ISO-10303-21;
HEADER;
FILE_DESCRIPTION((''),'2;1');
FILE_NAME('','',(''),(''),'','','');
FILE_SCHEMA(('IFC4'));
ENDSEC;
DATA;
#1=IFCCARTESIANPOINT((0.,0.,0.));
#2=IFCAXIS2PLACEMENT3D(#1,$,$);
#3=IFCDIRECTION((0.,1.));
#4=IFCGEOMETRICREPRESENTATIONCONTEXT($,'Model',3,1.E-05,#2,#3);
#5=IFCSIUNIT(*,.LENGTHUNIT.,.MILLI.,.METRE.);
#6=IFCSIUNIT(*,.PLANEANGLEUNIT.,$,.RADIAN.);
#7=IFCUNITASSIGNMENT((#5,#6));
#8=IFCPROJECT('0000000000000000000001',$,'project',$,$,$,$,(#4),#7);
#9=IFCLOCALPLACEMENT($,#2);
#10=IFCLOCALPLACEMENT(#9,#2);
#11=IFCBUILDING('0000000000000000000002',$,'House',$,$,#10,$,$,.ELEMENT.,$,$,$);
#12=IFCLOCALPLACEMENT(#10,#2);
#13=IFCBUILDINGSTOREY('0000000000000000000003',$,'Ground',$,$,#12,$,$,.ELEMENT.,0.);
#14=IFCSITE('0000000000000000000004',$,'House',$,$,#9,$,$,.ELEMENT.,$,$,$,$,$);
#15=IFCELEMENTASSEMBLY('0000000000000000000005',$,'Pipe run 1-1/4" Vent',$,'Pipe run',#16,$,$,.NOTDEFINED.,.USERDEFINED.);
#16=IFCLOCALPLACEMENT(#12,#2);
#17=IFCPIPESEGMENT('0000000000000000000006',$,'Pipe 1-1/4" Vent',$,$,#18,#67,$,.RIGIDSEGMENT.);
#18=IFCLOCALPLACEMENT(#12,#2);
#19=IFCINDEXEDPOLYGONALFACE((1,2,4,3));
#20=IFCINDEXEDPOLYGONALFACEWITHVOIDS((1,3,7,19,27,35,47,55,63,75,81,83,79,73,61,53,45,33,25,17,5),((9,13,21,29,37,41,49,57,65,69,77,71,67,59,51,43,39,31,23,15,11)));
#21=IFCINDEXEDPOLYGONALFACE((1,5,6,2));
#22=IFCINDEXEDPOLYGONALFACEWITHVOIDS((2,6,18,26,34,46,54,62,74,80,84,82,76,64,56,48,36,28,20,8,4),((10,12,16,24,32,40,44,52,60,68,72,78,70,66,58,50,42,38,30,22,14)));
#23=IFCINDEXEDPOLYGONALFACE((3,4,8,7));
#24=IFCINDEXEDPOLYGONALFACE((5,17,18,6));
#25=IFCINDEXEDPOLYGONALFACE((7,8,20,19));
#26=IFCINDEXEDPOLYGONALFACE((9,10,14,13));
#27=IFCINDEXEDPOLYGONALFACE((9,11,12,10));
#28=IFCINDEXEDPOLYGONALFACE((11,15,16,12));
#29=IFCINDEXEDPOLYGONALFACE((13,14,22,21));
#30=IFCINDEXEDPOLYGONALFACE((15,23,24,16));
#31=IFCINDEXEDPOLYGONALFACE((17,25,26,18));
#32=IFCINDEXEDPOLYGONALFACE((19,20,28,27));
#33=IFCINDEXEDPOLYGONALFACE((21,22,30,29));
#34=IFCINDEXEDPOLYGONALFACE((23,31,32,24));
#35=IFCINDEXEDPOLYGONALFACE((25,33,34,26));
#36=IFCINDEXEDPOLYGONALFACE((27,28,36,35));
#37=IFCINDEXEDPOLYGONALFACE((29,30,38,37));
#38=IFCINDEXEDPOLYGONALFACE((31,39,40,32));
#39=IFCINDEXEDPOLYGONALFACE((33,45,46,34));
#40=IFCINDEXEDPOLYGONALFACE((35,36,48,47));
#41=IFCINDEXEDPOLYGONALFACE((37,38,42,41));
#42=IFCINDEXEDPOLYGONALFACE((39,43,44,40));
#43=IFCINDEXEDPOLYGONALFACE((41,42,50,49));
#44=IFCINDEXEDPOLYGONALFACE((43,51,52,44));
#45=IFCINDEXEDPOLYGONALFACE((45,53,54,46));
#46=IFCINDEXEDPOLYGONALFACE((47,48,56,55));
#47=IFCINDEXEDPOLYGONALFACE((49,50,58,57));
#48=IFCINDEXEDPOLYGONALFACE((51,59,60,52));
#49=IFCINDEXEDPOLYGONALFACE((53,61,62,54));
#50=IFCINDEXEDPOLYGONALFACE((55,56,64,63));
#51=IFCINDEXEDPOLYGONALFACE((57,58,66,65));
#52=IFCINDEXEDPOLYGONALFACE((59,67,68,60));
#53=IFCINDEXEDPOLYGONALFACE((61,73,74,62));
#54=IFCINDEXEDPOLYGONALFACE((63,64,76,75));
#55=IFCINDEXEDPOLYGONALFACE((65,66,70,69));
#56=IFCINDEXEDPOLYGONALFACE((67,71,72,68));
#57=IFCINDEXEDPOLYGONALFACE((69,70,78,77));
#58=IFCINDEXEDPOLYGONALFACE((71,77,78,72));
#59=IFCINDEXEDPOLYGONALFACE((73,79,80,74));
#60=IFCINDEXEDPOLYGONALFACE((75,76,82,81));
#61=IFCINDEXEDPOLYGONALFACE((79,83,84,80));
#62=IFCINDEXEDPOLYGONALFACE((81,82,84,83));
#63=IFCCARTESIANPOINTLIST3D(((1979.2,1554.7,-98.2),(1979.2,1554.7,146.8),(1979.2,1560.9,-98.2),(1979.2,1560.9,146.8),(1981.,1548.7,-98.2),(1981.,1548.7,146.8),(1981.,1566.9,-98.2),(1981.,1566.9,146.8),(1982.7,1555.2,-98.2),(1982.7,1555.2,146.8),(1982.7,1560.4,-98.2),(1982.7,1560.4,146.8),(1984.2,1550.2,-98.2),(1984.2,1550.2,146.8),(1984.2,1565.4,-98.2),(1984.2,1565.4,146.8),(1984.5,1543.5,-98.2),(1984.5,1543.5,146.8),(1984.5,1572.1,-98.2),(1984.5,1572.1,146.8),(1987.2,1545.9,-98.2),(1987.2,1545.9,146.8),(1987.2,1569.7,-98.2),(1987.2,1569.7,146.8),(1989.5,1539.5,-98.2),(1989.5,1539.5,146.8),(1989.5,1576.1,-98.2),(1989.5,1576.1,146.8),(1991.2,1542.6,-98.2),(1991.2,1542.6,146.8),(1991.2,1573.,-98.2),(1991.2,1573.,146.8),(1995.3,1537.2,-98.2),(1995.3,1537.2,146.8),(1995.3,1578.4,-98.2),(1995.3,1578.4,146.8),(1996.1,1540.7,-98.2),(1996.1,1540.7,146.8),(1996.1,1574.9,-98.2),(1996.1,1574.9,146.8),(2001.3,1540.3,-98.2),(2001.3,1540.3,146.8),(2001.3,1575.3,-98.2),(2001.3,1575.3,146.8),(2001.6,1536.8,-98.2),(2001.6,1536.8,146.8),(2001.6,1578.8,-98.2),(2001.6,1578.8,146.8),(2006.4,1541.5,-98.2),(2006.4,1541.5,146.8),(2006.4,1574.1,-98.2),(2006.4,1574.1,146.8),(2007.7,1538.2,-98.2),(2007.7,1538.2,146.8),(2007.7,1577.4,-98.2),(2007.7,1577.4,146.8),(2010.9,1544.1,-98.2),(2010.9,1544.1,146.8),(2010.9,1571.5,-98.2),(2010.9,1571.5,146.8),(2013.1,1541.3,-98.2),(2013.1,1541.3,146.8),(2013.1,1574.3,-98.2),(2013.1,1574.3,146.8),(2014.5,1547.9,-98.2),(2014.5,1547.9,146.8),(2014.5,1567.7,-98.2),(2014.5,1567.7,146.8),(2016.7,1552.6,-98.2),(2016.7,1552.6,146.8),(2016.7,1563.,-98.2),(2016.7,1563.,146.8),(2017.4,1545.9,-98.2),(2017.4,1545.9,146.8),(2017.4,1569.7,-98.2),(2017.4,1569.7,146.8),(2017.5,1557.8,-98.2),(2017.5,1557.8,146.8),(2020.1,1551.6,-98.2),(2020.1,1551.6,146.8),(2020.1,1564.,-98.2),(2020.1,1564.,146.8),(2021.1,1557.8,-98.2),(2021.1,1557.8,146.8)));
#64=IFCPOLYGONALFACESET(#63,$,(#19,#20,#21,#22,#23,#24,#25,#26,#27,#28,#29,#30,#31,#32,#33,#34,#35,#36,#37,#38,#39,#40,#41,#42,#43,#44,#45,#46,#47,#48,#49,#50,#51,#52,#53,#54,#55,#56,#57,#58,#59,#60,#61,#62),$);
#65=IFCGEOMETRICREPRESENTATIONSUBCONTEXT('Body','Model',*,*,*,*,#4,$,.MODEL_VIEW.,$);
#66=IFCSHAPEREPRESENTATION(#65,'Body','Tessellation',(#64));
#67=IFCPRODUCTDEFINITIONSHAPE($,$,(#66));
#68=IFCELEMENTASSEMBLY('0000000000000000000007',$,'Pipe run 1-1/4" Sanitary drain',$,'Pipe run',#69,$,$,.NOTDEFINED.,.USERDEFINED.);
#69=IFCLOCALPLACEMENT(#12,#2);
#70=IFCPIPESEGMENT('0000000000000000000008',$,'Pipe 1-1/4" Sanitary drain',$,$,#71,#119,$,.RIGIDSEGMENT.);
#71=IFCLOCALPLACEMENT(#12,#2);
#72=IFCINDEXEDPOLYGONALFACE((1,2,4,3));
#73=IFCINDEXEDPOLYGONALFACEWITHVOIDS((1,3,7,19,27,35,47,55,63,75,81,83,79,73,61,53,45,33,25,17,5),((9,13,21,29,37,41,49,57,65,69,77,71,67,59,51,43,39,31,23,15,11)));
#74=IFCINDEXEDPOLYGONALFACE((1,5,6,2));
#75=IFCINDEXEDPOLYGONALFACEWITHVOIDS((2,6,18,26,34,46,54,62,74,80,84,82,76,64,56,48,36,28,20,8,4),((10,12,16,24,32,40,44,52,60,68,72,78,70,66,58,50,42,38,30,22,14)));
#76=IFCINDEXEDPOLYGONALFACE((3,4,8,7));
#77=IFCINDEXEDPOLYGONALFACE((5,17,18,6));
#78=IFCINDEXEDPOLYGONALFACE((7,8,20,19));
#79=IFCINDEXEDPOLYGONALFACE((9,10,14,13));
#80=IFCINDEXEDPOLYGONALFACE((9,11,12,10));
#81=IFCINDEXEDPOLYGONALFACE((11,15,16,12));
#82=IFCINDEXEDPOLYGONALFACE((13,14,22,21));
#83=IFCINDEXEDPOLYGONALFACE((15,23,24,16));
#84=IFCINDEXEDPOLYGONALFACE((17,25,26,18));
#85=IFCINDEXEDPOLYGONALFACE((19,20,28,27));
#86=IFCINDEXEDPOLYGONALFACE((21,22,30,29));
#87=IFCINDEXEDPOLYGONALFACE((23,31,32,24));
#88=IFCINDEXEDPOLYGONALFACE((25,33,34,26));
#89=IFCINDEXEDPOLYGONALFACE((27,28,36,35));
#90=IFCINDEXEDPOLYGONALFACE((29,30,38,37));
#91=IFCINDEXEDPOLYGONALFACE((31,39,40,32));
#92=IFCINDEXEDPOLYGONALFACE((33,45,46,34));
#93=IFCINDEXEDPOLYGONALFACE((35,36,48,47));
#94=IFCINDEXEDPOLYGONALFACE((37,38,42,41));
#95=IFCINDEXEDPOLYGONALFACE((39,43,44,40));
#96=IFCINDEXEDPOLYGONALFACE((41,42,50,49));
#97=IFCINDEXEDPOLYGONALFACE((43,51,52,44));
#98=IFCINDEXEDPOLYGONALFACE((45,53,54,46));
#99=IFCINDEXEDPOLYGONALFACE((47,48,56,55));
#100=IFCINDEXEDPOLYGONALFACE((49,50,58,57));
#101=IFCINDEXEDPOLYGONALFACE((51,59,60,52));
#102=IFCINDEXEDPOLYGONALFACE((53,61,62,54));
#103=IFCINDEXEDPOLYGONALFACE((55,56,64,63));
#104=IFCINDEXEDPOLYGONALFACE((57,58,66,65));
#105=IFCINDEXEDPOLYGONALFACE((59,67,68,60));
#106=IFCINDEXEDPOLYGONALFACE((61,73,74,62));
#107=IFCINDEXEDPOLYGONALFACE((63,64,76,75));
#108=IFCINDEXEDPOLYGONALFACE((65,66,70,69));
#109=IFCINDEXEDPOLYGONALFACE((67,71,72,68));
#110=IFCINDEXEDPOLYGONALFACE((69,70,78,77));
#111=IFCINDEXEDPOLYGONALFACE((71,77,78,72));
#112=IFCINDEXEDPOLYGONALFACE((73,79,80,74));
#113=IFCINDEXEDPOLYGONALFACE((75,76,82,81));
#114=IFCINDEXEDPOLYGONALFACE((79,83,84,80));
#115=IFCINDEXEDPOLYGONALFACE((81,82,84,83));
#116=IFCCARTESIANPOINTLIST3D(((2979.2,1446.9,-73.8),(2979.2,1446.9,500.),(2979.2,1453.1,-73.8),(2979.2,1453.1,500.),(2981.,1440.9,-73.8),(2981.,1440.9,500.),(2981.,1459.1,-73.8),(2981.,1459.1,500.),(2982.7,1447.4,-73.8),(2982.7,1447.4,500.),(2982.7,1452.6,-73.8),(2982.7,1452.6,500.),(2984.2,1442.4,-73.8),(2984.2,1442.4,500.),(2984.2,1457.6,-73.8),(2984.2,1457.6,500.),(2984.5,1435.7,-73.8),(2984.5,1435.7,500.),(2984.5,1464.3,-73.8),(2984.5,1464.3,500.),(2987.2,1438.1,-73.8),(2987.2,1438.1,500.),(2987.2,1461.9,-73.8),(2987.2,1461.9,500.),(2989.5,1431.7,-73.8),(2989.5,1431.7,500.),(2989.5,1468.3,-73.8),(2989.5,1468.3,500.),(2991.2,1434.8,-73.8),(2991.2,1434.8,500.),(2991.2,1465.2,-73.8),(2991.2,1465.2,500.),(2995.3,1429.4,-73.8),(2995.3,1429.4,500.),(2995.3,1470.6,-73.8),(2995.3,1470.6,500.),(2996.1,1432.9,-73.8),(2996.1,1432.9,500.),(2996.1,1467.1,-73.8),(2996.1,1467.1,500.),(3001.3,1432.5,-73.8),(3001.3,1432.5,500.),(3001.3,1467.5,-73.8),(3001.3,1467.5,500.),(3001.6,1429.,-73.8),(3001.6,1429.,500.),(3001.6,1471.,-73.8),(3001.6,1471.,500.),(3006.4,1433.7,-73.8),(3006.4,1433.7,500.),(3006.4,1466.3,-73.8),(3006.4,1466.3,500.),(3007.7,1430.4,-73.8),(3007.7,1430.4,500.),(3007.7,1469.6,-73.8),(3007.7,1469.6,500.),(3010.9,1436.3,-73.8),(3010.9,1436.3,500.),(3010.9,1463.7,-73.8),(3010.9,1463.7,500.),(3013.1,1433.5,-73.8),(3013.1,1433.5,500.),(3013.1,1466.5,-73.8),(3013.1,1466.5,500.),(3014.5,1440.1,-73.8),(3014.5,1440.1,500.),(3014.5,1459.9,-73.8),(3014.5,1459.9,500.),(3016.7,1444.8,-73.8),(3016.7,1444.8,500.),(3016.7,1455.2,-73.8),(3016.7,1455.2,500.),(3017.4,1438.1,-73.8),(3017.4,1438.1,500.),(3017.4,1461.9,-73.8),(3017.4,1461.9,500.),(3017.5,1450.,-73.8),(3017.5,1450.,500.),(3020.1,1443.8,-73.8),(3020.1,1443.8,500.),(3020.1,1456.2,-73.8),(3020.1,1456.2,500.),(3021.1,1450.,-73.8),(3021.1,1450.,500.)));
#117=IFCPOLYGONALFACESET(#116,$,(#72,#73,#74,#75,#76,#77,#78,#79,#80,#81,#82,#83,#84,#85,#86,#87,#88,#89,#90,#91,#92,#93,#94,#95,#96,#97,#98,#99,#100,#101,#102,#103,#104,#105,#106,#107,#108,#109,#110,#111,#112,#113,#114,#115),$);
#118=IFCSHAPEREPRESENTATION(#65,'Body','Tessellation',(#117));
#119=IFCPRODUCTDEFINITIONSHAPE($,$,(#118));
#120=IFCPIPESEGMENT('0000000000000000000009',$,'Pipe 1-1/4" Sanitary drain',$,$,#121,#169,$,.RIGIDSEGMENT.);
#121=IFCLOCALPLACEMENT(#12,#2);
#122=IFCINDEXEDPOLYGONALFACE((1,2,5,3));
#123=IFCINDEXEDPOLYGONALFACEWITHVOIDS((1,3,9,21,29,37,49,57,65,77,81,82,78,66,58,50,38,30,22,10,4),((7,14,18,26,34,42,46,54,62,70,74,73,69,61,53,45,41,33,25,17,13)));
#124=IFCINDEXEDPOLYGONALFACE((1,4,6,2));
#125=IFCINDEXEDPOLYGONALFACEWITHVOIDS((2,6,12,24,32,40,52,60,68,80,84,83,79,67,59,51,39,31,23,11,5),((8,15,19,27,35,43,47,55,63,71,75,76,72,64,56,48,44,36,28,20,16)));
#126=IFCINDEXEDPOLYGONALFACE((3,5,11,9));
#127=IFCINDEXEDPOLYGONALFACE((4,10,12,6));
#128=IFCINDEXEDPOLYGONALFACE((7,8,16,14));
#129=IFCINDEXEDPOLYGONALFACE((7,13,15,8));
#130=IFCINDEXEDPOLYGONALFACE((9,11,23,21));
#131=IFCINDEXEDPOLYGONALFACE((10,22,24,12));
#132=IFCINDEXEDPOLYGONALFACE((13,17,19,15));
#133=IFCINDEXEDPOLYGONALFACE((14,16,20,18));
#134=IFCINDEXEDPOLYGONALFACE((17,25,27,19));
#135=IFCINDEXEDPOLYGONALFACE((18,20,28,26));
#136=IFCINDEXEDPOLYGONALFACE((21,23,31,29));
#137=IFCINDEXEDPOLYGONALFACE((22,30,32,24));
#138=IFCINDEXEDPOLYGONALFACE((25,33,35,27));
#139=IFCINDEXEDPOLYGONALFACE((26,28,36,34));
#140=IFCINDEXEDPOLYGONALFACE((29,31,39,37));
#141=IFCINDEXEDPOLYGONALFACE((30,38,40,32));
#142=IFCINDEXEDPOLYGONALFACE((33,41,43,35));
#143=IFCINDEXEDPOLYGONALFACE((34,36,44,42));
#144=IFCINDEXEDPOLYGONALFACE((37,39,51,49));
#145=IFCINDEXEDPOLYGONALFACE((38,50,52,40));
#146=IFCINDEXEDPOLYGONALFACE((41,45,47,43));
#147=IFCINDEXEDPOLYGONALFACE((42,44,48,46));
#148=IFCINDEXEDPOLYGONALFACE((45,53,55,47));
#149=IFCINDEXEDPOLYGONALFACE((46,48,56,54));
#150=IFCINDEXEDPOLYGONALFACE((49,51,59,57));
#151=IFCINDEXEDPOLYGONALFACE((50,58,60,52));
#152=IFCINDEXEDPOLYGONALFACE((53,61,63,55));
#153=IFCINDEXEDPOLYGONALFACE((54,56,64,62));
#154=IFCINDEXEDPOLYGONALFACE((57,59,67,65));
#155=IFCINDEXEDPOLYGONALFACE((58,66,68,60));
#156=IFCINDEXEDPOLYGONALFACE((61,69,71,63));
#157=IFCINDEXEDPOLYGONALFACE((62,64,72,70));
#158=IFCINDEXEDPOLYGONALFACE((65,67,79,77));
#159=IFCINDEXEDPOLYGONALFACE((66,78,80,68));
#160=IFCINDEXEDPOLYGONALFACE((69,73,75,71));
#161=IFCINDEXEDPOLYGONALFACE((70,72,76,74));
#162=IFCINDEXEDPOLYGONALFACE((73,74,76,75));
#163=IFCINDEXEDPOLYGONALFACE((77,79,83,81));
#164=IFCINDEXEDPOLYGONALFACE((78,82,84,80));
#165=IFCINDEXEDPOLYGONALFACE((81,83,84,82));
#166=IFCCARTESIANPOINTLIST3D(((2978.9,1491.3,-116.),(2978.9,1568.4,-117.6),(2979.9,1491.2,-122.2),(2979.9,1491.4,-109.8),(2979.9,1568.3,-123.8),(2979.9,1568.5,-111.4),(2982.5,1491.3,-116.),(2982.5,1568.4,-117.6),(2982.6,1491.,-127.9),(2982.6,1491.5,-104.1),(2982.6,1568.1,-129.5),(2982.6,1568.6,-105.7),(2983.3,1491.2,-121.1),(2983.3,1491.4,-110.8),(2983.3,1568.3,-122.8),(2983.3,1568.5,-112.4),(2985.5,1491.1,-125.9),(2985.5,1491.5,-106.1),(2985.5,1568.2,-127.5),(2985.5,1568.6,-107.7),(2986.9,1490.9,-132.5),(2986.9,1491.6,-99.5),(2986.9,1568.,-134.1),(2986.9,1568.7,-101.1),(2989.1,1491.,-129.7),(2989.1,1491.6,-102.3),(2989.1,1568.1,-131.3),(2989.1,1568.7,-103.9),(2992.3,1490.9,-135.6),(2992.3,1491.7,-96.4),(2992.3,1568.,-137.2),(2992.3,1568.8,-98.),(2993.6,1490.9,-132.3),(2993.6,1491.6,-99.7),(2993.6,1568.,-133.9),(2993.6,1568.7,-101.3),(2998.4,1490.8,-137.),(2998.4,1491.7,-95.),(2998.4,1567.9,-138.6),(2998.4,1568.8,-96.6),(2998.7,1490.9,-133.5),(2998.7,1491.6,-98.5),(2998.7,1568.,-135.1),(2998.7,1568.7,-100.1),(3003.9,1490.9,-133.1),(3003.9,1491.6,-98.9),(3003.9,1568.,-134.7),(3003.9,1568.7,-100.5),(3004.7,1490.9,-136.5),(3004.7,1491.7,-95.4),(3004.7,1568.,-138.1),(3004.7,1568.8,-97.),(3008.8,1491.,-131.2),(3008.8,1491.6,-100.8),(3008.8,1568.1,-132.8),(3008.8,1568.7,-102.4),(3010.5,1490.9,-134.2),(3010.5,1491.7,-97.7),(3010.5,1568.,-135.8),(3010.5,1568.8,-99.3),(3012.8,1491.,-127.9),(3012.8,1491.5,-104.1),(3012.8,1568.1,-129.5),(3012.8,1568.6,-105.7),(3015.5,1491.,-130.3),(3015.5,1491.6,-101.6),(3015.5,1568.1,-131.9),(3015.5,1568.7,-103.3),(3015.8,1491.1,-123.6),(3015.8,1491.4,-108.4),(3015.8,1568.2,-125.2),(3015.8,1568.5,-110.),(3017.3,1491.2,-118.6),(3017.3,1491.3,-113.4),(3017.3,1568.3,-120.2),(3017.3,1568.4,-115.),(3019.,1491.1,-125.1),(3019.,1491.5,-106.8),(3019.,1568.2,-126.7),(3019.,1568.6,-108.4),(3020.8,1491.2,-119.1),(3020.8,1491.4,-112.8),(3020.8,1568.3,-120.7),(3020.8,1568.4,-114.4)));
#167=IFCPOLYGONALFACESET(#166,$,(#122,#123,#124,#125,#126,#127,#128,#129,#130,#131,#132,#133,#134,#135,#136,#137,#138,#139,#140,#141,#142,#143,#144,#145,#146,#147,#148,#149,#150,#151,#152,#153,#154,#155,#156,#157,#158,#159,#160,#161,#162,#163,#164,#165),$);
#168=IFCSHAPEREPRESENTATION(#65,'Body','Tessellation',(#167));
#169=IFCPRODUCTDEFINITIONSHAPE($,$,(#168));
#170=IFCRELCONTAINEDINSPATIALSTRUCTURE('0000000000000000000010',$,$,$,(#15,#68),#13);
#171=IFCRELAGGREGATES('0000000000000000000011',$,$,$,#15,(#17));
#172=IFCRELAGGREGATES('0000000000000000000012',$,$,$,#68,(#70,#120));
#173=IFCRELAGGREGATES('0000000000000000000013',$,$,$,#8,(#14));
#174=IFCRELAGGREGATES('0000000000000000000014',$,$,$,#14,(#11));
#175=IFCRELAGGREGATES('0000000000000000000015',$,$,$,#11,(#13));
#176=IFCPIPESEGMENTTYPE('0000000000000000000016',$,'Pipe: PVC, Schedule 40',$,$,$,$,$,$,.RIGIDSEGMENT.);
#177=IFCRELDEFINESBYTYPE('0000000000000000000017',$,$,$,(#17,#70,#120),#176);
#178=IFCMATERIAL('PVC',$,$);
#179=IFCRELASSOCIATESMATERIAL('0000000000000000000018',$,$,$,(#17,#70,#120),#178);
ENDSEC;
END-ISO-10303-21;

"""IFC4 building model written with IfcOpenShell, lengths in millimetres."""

from ifc_helpers import new_model, si_unit, direction, frame, origin, origin_with_axes, origin_2d, place, context, subcontext, project, spatial, hollow_circle, extrude, material, type_object, element, aggregate, save


model = new_model("IFC4")

# Units and contexts
model_context = context("Model", 3, precision=1e-05, world=origin(), true_north=direction((0.0, 1.0)))
body_context = subcontext(model_context, "Body", "Model", "MODEL_VIEW")
ifc_project = project(units=[si_unit("LENGTHUNIT", "METRE", prefix="MILLI"), si_unit("PLANEANGLEUNIT", "RADIAN")], contexts=[model_context])

# Site, building, storey
site_placement = place(None, origin())
site = spatial("IfcSite", under=ifc_project, at=site_placement, Name="House", CompositionType="ELEMENT")
building_placement = place(site_placement, origin())
building = spatial("IfcBuilding", under=site, at=building_placement, Name="House", CompositionType="ELEMENT")
storey_placement = place(building_placement, origin())
storey = spatial("IfcBuildingStorey", under=building, at=storey_placement, Name="Ground", CompositionType="ELEMENT", Elevation=0.0)

# Element assembly, pipe segment
ifc_material = material(Name="PVC")
pipe_segment_type = type_object("IfcPipeSegmentType", Name="Pipe: PVC, Schedule 40", PredefinedType="RIGIDSEGMENT")
assembly_1_placement = place(storey_placement, origin_with_axes())
assembly_1 = element("IfcElementAssembly", 1, at=assembly_1_placement, inside=storey, Name="Pipe run 1-1/4\" Vent", ObjectType="Pipe run", AssemblyPlace="NOTDEFINED", PredefinedType="USERDEFINED")
pipe_segment_1_placement = place(storey_placement, origin_with_axes())
pipe_segment_1 = element("IfcPipeSegment", 2, at=pipe_segment_1_placement, type_object=pipe_segment_type, material=ifc_material, Name="Pipe 1-1/4\" Vent", PredefinedType="RIGIDSEGMENT", context=body_context, shape_type="SweptSolid", body=[
    extrude(hollow_circle(Radius=21.1, WallThickness=3.6, at=origin_2d()), frame((2000.0, 1557.8, 146.8), z_axis=(0.0, 0.0, -1.0), x_axis=(1.0, 0.0, 0.0)), (0.0, 0.0, 1.0), 245.0),
])
aggregate(assembly_1, [pipe_segment_1])

# Element assembly, pipe segments
assembly_2_placement = place(storey_placement, origin_with_axes())
assembly_2 = element("IfcElementAssembly", 3, at=assembly_2_placement, inside=storey, Name="Pipe run 1-1/4\" Sanitary drain", ObjectType="Pipe run", AssemblyPlace="NOTDEFINED", PredefinedType="USERDEFINED")
pipe_segment_2_placement = place(storey_placement, origin_with_axes())
pipe_segment_2 = element("IfcPipeSegment", 4, at=pipe_segment_2_placement, type_object=pipe_segment_type, material=ifc_material, Name="Pipe 1-1/4\" Sanitary drain", PredefinedType="RIGIDSEGMENT", context=body_context, shape_type="SweptSolid", body=[
    extrude(hollow_circle(Radius=21.1, WallThickness=3.6, at=origin_2d()), frame((3000.0, 1450.0, 500.0), z_axis=(0.0, 0.0, -1.0), x_axis=(1.0, 0.0, 0.0)), (0.0, 0.0, 1.0), 573.8),
])
pipe_segment_3_placement = place(storey_placement, origin_with_axes())
pipe_segment_3 = element("IfcPipeSegment", 5, at=pipe_segment_3_placement, type_object=pipe_segment_type, material=ifc_material, Name="Pipe 1-1/4\" Sanitary drain", PredefinedType="RIGIDSEGMENT", context=body_context, shape_type="SweptSolid", body=[
    extrude(hollow_circle(Radius=21.1, WallThickness=3.6, at=origin_2d()), frame((3000.0, 1491.3, -116.0), z_axis=(0.0, 0.999783, -0.020829), x_axis=(-1.0, 0.0, 0.0)), (0.0, 0.0, 1.0), 77.1),
])

aggregate(assembly_2, [pipe_segment_2, pipe_segment_3])

save(model, "model.ifc")
